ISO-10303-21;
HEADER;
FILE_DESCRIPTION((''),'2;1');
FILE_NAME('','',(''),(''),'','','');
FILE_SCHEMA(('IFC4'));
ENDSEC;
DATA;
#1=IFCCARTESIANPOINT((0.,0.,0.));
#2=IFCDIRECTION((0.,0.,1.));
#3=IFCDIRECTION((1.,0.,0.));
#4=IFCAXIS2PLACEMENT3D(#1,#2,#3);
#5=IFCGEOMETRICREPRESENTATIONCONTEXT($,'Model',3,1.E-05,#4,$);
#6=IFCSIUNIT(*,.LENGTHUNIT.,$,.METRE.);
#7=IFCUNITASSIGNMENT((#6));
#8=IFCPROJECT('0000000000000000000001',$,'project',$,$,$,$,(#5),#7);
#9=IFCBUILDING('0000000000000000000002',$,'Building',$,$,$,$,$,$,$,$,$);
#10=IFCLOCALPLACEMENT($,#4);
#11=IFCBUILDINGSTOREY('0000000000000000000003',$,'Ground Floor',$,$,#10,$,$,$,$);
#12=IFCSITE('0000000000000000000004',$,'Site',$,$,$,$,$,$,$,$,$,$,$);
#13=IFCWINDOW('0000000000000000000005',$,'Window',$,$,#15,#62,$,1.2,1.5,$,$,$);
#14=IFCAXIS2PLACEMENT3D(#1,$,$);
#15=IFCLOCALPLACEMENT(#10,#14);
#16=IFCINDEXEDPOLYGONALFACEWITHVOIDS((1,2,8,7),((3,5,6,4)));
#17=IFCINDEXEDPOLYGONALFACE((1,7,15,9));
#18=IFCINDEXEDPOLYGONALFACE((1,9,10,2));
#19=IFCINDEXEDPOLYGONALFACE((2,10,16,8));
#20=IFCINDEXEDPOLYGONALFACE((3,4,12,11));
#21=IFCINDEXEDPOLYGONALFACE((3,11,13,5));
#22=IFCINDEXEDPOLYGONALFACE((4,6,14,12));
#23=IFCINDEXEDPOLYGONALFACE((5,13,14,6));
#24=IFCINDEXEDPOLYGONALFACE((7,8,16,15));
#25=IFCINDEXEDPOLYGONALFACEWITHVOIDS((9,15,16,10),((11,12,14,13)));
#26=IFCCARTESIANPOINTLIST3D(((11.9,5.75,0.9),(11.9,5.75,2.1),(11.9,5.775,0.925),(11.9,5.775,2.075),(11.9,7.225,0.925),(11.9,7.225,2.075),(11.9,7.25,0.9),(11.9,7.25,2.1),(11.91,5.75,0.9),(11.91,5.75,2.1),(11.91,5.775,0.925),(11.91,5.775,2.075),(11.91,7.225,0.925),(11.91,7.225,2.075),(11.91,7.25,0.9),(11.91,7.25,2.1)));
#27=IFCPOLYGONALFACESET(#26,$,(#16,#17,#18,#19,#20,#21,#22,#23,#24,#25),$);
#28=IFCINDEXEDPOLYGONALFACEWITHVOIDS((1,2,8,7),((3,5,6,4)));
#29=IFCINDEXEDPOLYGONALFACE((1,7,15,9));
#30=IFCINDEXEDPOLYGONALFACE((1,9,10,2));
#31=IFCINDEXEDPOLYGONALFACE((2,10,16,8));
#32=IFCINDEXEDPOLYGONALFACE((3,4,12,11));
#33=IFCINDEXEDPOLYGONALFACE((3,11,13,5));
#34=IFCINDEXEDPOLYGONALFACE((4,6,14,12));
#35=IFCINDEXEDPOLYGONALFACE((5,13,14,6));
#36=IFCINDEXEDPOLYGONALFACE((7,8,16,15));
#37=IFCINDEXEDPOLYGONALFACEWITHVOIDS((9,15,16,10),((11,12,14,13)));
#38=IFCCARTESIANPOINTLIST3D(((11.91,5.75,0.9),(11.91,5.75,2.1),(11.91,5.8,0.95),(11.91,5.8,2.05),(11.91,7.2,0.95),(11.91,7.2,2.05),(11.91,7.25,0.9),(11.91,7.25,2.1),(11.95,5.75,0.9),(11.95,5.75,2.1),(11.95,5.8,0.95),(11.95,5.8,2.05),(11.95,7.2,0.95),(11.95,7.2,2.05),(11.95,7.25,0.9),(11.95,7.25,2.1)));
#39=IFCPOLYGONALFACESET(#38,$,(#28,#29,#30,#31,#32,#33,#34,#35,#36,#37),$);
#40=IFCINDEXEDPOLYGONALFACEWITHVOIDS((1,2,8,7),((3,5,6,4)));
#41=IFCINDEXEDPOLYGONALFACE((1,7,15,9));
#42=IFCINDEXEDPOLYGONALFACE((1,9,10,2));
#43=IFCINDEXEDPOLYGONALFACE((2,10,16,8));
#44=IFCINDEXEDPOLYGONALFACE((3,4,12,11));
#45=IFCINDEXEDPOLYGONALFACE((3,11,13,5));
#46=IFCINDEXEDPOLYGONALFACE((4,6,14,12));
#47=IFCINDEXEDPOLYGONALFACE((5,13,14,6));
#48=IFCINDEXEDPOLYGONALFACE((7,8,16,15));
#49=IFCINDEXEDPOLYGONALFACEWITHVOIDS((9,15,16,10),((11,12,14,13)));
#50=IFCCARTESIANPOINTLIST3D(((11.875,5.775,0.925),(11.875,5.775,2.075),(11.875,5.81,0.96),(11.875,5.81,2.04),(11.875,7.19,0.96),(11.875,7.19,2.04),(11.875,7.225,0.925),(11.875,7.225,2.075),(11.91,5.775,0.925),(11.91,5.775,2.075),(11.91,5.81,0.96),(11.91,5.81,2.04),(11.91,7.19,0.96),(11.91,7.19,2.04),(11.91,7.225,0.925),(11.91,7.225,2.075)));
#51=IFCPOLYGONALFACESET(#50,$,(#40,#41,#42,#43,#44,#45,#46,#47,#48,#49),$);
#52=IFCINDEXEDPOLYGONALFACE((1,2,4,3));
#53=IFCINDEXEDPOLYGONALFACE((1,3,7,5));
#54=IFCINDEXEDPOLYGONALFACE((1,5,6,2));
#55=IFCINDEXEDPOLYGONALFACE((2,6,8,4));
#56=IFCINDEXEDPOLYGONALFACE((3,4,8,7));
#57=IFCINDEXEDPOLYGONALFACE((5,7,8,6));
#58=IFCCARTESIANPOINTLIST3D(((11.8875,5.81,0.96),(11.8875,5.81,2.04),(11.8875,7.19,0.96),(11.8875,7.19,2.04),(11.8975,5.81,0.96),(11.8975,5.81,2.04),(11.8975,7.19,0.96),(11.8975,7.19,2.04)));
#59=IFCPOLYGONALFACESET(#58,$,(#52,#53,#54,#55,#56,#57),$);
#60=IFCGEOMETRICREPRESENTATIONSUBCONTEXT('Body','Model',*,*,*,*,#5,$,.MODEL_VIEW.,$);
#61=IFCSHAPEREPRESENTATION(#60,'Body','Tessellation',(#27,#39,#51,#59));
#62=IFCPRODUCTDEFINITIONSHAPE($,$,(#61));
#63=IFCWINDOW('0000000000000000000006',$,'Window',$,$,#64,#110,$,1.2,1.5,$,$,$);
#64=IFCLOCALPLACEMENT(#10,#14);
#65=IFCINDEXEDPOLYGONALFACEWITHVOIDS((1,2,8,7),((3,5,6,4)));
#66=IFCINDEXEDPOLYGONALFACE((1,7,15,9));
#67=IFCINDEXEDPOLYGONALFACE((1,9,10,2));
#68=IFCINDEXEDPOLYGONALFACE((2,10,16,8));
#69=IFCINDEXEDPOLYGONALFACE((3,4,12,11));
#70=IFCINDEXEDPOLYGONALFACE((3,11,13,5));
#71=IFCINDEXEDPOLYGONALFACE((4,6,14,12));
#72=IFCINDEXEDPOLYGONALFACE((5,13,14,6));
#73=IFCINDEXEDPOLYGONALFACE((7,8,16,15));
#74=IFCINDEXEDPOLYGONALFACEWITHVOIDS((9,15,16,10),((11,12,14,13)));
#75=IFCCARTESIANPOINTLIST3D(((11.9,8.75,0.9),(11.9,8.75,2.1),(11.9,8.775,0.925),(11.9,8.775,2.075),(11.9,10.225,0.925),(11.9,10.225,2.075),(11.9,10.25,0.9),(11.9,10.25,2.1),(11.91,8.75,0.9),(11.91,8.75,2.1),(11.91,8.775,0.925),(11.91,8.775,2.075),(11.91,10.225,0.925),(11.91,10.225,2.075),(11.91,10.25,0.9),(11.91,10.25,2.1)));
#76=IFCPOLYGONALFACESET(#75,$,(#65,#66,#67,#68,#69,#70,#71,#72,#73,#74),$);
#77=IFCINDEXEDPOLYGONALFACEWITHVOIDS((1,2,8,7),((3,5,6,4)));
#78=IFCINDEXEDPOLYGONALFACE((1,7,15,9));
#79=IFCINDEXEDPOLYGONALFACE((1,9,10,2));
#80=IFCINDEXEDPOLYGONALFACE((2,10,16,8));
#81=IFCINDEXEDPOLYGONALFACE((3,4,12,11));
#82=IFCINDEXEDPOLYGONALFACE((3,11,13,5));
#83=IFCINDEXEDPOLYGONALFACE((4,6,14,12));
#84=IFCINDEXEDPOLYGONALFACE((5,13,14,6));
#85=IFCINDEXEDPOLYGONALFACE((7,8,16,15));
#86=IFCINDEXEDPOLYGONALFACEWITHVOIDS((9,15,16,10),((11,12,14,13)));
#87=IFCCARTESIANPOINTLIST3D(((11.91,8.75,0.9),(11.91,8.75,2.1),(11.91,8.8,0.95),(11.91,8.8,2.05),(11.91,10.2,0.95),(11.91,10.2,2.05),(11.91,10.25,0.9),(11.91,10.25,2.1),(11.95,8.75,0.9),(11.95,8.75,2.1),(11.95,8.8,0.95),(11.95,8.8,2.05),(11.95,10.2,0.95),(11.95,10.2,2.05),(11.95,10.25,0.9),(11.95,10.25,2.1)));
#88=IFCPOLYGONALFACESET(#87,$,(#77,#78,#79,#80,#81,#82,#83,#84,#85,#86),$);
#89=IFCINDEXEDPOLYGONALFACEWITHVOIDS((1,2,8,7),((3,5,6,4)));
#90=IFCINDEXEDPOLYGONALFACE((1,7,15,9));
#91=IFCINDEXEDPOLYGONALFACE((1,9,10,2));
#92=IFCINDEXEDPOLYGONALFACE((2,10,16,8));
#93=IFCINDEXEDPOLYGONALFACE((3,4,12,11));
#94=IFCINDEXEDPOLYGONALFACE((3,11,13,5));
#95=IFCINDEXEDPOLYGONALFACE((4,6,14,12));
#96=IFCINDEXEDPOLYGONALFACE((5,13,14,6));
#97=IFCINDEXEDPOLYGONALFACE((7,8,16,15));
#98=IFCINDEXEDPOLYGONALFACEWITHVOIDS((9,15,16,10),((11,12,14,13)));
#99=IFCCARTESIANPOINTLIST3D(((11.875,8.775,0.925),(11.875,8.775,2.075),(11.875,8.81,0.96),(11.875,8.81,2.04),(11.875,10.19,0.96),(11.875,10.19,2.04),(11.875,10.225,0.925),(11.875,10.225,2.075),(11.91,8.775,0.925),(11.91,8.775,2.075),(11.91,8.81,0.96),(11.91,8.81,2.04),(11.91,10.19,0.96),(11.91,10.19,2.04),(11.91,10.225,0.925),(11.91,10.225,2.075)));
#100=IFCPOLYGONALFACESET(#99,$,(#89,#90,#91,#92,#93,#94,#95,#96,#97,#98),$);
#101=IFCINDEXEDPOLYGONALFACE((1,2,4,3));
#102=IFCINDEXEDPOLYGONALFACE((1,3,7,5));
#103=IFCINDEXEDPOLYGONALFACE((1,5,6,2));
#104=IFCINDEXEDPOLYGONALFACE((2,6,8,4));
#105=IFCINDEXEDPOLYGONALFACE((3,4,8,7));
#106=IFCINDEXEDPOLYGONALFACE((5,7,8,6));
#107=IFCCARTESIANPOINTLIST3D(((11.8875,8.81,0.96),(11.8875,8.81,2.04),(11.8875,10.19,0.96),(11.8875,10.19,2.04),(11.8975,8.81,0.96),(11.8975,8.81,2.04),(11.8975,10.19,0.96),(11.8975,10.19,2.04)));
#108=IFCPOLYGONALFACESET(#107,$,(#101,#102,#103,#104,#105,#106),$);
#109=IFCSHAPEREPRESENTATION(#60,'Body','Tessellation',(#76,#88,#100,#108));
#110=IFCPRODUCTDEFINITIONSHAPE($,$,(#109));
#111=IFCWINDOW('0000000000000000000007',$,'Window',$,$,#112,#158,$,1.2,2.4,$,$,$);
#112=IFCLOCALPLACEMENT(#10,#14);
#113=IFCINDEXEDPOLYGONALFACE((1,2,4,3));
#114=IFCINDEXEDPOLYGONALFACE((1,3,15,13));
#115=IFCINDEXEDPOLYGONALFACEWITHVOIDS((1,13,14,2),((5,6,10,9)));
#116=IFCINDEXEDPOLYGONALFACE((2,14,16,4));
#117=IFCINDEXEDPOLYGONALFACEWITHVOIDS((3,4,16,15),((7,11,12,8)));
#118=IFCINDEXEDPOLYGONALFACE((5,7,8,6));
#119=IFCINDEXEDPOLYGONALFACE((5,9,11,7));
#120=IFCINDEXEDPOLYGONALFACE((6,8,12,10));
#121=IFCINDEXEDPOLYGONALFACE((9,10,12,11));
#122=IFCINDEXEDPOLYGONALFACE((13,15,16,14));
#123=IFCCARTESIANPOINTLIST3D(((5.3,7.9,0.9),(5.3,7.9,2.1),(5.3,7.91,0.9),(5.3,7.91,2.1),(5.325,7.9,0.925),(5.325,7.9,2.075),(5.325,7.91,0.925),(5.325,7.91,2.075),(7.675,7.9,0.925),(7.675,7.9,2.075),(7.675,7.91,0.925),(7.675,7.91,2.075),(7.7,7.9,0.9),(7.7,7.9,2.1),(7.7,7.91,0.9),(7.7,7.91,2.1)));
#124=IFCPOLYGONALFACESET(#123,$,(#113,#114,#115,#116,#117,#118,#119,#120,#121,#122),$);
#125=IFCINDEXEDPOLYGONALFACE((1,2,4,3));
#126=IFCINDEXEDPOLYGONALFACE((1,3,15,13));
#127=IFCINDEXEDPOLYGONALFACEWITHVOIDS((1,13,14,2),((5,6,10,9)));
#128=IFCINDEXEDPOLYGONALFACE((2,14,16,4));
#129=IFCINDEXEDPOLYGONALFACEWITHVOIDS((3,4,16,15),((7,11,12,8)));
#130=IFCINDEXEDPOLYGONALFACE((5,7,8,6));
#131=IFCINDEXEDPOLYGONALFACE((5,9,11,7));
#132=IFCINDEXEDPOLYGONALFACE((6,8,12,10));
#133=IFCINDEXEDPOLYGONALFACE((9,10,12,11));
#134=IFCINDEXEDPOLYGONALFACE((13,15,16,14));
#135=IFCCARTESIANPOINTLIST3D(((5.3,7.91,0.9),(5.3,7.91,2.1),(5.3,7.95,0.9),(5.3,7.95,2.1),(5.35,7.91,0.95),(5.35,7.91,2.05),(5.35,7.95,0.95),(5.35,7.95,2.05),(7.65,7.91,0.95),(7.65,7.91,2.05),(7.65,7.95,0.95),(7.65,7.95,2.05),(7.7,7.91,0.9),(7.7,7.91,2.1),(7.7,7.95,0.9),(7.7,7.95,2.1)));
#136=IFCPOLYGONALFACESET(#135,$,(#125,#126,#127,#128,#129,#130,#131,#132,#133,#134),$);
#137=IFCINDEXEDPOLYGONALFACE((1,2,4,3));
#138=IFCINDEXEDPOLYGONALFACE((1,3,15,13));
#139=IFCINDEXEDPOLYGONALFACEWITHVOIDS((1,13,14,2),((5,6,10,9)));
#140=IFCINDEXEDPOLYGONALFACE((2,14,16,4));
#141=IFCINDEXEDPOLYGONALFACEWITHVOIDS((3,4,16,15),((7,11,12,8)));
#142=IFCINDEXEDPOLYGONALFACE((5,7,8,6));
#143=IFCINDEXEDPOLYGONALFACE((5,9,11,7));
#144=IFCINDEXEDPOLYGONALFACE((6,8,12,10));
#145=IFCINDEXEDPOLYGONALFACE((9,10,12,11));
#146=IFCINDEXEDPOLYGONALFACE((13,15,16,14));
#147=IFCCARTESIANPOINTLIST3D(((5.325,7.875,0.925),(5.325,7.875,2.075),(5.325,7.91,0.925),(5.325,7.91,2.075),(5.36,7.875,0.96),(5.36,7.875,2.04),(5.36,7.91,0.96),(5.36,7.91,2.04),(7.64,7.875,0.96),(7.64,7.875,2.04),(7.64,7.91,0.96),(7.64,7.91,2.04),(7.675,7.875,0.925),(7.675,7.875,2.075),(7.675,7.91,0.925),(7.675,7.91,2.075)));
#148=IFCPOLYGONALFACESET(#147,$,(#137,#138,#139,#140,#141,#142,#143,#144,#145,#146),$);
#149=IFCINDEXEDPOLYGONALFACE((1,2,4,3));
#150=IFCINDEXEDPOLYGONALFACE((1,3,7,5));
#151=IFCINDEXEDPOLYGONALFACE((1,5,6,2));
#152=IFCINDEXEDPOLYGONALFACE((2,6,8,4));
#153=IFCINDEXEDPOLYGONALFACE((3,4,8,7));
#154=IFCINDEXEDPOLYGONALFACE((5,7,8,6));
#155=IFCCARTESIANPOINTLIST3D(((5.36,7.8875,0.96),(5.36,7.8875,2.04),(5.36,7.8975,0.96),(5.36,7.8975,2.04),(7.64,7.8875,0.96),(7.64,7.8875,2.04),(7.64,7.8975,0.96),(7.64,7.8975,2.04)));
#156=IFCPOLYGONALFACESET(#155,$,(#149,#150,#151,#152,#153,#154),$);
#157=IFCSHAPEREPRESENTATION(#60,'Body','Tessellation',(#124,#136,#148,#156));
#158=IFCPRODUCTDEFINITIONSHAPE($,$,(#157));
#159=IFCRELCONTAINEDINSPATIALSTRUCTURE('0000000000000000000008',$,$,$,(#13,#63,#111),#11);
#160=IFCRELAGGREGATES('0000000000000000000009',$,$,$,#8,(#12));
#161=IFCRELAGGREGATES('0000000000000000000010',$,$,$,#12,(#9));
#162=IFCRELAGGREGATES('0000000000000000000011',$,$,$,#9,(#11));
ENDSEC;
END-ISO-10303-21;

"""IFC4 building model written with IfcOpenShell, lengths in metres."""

from ifc_helpers import new_model, si_unit, frame, origin_with_axes, place, context, subcontext, project, spatial, line, indexed_curve, outline, extrude, element, save


model = new_model("IFC4")

# Units and contexts
model_context = context("Model", 3, precision=1e-05, world=origin_with_axes())
body_context = subcontext(model_context, "Body", "Model", "MODEL_VIEW")
ifc_project = project(units=[si_unit("LENGTHUNIT", "METRE")], contexts=[model_context])

# Site, building, storey
site = spatial("IfcSite", under=ifc_project, Name="Site")
building = spatial("IfcBuilding", under=site, Name="Building")
storey_placement = place(None, origin_with_axes())
storey = spatial("IfcBuildingStorey", under=building, at=storey_placement, Name="Ground Floor")

# Windows
for number, where, z_axis, x_axis, name in (
    (1, (12.0, 5.75, 0.9), (0.0, 0.0, 1.0), (0.0, 1.0, 0.0), "Window"),
    (2, (12.0, 8.75, 0.9), (0.0, 0.0, 1.0), (0.0, 1.0, 0.0), "Window"),
):
    element("IfcWindow", number, at=place(storey_placement, frame(where, z_axis=z_axis, x_axis=x_axis)), inside=storey, Name=name, OverallHeight=1.2, OverallWidth=1.5, context=body_context, shape_type="SweptSolid", body=[
        extrude(outline(indexed_curve([(0.0, 0.0), (1.5, 0.0), (1.5, 1.2), (0.0, 1.2)], segments=[line(1, 2, 3, 4, 1)]), holes=[indexed_curve([(0.025, 0.025), (1.475, 0.025), (1.475, 1.175), (0.025, 1.175)], segments=[line(1, 2, 3, 4, 1)])]), frame((0.0, 0.09, 0.0), z_axis=(0.0, -1.0, 0.0), x_axis=(1.0, 0.0, 0.0)), (0.0, 0.0, -1.0), 0.01),
        extrude(outline(indexed_curve([(0.0, 0.0), (1.5, 0.0), (1.5, 1.2), (0.0, 1.2)], segments=[line(1, 2, 3, 4, 1)]), holes=[indexed_curve([(0.05, 0.05), (1.45, 0.05), (1.45, 1.15), (0.05, 1.15)], segments=[line(1, 2, 3, 4, 1)])]), frame((0.0, 0.05, 0.0), z_axis=(0.0, -1.0, 0.0), x_axis=(1.0, 0.0, 0.0)), (0.0, 0.0, -1.0), 0.04),
        extrude(outline(indexed_curve([(0.0, 0.0), (1.45, 0.0), (1.45, 1.15), (0.0, 1.15)], segments=[line(1, 2, 3, 4, 1)]), holes=[indexed_curve([(0.035, 0.035), (1.415, 0.035), (1.415, 1.115), (0.035, 1.115)], segments=[line(1, 2, 3, 4, 1)])]), frame((0.025, 0.09, 0.025), z_axis=(0.0, -1.0, 0.0), x_axis=(1.0, 0.0, 0.0)), (0.0, 0.0, -1.0), 0.035),
        extrude(outline(indexed_curve([(0.035, 0.035), (1.415, 0.035), (1.415, 1.115), (0.035, 1.115)], segments=[line(1, 2, 3, 4, 1)])), frame((0.025, 0.1025, 0.025), z_axis=(0.0, -1.0, 0.0), x_axis=(1.0, 0.0, 0.0)), (0.0, 0.0, -1.0), 0.01),
    ])
window_1_placement = place(storey_placement, frame((7.7, 8.0, 0.9), z_axis=(0.0, 0.0, 1.0), x_axis=(-1.0, 0.0, 0.0)))
element("IfcWindow", 3, at=window_1_placement, inside=storey, Name="Window", OverallHeight=1.2, OverallWidth=2.4, context=body_context, shape_type="SweptSolid", body=[
    extrude(outline(indexed_curve([(0.0, 0.0), (2.4, 0.0), (2.4, 1.2), (0.0, 1.2)], segments=[line(1, 2, 3, 4, 1)]), holes=[indexed_curve([(0.025, 0.025), (2.375, 0.025), (2.375, 1.175), (0.025, 1.175)], segments=[line(1, 2, 3, 4, 1)])]), frame((0.0, 0.09, 0.0), z_axis=(0.0, -1.0, 0.0), x_axis=(1.0, 0.0, 0.0)), (0.0, 0.0, -1.0), 0.01),
    extrude(outline(indexed_curve([(0.0, 0.0), (2.4, 0.0), (2.4, 1.2), (0.0, 1.2)], segments=[line(1, 2, 3, 4, 1)]), holes=[indexed_curve([(0.05, 0.05), (2.35, 0.05), (2.35, 1.15), (0.05, 1.15)], segments=[line(1, 2, 3, 4, 1)])]), frame((0.0, 0.05, 0.0), z_axis=(0.0, -1.0, 0.0), x_axis=(1.0, 0.0, 0.0)), (0.0, 0.0, -1.0), 0.04),
    extrude(outline(indexed_curve([(0.0, 0.0), (2.35, 0.0), (2.35, 1.15), (0.0, 1.15)], segments=[line(1, 2, 3, 4, 1)]), holes=[indexed_curve([(0.035, 0.035), (2.315, 0.035), (2.315, 1.115), (0.035, 1.115)], segments=[line(1, 2, 3, 4, 1)])]), frame((0.025, 0.09, 0.025), z_axis=(0.0, -1.0, 0.0), x_axis=(1.0, 0.0, 0.0)), (0.0, 0.0, -1.0), 0.035),
    extrude(outline(indexed_curve([(0.035, 0.035), (2.315, 0.035), (2.315, 1.115), (0.035, 1.115)], segments=[line(1, 2, 3, 4, 1)])), frame((0.025, 0.1025, 0.025), z_axis=(0.0, -1.0, 0.0), x_axis=(1.0, 0.0, 0.0)), (0.0, 0.0, -1.0), 0.01),
])

save(model, "model.ifc")
